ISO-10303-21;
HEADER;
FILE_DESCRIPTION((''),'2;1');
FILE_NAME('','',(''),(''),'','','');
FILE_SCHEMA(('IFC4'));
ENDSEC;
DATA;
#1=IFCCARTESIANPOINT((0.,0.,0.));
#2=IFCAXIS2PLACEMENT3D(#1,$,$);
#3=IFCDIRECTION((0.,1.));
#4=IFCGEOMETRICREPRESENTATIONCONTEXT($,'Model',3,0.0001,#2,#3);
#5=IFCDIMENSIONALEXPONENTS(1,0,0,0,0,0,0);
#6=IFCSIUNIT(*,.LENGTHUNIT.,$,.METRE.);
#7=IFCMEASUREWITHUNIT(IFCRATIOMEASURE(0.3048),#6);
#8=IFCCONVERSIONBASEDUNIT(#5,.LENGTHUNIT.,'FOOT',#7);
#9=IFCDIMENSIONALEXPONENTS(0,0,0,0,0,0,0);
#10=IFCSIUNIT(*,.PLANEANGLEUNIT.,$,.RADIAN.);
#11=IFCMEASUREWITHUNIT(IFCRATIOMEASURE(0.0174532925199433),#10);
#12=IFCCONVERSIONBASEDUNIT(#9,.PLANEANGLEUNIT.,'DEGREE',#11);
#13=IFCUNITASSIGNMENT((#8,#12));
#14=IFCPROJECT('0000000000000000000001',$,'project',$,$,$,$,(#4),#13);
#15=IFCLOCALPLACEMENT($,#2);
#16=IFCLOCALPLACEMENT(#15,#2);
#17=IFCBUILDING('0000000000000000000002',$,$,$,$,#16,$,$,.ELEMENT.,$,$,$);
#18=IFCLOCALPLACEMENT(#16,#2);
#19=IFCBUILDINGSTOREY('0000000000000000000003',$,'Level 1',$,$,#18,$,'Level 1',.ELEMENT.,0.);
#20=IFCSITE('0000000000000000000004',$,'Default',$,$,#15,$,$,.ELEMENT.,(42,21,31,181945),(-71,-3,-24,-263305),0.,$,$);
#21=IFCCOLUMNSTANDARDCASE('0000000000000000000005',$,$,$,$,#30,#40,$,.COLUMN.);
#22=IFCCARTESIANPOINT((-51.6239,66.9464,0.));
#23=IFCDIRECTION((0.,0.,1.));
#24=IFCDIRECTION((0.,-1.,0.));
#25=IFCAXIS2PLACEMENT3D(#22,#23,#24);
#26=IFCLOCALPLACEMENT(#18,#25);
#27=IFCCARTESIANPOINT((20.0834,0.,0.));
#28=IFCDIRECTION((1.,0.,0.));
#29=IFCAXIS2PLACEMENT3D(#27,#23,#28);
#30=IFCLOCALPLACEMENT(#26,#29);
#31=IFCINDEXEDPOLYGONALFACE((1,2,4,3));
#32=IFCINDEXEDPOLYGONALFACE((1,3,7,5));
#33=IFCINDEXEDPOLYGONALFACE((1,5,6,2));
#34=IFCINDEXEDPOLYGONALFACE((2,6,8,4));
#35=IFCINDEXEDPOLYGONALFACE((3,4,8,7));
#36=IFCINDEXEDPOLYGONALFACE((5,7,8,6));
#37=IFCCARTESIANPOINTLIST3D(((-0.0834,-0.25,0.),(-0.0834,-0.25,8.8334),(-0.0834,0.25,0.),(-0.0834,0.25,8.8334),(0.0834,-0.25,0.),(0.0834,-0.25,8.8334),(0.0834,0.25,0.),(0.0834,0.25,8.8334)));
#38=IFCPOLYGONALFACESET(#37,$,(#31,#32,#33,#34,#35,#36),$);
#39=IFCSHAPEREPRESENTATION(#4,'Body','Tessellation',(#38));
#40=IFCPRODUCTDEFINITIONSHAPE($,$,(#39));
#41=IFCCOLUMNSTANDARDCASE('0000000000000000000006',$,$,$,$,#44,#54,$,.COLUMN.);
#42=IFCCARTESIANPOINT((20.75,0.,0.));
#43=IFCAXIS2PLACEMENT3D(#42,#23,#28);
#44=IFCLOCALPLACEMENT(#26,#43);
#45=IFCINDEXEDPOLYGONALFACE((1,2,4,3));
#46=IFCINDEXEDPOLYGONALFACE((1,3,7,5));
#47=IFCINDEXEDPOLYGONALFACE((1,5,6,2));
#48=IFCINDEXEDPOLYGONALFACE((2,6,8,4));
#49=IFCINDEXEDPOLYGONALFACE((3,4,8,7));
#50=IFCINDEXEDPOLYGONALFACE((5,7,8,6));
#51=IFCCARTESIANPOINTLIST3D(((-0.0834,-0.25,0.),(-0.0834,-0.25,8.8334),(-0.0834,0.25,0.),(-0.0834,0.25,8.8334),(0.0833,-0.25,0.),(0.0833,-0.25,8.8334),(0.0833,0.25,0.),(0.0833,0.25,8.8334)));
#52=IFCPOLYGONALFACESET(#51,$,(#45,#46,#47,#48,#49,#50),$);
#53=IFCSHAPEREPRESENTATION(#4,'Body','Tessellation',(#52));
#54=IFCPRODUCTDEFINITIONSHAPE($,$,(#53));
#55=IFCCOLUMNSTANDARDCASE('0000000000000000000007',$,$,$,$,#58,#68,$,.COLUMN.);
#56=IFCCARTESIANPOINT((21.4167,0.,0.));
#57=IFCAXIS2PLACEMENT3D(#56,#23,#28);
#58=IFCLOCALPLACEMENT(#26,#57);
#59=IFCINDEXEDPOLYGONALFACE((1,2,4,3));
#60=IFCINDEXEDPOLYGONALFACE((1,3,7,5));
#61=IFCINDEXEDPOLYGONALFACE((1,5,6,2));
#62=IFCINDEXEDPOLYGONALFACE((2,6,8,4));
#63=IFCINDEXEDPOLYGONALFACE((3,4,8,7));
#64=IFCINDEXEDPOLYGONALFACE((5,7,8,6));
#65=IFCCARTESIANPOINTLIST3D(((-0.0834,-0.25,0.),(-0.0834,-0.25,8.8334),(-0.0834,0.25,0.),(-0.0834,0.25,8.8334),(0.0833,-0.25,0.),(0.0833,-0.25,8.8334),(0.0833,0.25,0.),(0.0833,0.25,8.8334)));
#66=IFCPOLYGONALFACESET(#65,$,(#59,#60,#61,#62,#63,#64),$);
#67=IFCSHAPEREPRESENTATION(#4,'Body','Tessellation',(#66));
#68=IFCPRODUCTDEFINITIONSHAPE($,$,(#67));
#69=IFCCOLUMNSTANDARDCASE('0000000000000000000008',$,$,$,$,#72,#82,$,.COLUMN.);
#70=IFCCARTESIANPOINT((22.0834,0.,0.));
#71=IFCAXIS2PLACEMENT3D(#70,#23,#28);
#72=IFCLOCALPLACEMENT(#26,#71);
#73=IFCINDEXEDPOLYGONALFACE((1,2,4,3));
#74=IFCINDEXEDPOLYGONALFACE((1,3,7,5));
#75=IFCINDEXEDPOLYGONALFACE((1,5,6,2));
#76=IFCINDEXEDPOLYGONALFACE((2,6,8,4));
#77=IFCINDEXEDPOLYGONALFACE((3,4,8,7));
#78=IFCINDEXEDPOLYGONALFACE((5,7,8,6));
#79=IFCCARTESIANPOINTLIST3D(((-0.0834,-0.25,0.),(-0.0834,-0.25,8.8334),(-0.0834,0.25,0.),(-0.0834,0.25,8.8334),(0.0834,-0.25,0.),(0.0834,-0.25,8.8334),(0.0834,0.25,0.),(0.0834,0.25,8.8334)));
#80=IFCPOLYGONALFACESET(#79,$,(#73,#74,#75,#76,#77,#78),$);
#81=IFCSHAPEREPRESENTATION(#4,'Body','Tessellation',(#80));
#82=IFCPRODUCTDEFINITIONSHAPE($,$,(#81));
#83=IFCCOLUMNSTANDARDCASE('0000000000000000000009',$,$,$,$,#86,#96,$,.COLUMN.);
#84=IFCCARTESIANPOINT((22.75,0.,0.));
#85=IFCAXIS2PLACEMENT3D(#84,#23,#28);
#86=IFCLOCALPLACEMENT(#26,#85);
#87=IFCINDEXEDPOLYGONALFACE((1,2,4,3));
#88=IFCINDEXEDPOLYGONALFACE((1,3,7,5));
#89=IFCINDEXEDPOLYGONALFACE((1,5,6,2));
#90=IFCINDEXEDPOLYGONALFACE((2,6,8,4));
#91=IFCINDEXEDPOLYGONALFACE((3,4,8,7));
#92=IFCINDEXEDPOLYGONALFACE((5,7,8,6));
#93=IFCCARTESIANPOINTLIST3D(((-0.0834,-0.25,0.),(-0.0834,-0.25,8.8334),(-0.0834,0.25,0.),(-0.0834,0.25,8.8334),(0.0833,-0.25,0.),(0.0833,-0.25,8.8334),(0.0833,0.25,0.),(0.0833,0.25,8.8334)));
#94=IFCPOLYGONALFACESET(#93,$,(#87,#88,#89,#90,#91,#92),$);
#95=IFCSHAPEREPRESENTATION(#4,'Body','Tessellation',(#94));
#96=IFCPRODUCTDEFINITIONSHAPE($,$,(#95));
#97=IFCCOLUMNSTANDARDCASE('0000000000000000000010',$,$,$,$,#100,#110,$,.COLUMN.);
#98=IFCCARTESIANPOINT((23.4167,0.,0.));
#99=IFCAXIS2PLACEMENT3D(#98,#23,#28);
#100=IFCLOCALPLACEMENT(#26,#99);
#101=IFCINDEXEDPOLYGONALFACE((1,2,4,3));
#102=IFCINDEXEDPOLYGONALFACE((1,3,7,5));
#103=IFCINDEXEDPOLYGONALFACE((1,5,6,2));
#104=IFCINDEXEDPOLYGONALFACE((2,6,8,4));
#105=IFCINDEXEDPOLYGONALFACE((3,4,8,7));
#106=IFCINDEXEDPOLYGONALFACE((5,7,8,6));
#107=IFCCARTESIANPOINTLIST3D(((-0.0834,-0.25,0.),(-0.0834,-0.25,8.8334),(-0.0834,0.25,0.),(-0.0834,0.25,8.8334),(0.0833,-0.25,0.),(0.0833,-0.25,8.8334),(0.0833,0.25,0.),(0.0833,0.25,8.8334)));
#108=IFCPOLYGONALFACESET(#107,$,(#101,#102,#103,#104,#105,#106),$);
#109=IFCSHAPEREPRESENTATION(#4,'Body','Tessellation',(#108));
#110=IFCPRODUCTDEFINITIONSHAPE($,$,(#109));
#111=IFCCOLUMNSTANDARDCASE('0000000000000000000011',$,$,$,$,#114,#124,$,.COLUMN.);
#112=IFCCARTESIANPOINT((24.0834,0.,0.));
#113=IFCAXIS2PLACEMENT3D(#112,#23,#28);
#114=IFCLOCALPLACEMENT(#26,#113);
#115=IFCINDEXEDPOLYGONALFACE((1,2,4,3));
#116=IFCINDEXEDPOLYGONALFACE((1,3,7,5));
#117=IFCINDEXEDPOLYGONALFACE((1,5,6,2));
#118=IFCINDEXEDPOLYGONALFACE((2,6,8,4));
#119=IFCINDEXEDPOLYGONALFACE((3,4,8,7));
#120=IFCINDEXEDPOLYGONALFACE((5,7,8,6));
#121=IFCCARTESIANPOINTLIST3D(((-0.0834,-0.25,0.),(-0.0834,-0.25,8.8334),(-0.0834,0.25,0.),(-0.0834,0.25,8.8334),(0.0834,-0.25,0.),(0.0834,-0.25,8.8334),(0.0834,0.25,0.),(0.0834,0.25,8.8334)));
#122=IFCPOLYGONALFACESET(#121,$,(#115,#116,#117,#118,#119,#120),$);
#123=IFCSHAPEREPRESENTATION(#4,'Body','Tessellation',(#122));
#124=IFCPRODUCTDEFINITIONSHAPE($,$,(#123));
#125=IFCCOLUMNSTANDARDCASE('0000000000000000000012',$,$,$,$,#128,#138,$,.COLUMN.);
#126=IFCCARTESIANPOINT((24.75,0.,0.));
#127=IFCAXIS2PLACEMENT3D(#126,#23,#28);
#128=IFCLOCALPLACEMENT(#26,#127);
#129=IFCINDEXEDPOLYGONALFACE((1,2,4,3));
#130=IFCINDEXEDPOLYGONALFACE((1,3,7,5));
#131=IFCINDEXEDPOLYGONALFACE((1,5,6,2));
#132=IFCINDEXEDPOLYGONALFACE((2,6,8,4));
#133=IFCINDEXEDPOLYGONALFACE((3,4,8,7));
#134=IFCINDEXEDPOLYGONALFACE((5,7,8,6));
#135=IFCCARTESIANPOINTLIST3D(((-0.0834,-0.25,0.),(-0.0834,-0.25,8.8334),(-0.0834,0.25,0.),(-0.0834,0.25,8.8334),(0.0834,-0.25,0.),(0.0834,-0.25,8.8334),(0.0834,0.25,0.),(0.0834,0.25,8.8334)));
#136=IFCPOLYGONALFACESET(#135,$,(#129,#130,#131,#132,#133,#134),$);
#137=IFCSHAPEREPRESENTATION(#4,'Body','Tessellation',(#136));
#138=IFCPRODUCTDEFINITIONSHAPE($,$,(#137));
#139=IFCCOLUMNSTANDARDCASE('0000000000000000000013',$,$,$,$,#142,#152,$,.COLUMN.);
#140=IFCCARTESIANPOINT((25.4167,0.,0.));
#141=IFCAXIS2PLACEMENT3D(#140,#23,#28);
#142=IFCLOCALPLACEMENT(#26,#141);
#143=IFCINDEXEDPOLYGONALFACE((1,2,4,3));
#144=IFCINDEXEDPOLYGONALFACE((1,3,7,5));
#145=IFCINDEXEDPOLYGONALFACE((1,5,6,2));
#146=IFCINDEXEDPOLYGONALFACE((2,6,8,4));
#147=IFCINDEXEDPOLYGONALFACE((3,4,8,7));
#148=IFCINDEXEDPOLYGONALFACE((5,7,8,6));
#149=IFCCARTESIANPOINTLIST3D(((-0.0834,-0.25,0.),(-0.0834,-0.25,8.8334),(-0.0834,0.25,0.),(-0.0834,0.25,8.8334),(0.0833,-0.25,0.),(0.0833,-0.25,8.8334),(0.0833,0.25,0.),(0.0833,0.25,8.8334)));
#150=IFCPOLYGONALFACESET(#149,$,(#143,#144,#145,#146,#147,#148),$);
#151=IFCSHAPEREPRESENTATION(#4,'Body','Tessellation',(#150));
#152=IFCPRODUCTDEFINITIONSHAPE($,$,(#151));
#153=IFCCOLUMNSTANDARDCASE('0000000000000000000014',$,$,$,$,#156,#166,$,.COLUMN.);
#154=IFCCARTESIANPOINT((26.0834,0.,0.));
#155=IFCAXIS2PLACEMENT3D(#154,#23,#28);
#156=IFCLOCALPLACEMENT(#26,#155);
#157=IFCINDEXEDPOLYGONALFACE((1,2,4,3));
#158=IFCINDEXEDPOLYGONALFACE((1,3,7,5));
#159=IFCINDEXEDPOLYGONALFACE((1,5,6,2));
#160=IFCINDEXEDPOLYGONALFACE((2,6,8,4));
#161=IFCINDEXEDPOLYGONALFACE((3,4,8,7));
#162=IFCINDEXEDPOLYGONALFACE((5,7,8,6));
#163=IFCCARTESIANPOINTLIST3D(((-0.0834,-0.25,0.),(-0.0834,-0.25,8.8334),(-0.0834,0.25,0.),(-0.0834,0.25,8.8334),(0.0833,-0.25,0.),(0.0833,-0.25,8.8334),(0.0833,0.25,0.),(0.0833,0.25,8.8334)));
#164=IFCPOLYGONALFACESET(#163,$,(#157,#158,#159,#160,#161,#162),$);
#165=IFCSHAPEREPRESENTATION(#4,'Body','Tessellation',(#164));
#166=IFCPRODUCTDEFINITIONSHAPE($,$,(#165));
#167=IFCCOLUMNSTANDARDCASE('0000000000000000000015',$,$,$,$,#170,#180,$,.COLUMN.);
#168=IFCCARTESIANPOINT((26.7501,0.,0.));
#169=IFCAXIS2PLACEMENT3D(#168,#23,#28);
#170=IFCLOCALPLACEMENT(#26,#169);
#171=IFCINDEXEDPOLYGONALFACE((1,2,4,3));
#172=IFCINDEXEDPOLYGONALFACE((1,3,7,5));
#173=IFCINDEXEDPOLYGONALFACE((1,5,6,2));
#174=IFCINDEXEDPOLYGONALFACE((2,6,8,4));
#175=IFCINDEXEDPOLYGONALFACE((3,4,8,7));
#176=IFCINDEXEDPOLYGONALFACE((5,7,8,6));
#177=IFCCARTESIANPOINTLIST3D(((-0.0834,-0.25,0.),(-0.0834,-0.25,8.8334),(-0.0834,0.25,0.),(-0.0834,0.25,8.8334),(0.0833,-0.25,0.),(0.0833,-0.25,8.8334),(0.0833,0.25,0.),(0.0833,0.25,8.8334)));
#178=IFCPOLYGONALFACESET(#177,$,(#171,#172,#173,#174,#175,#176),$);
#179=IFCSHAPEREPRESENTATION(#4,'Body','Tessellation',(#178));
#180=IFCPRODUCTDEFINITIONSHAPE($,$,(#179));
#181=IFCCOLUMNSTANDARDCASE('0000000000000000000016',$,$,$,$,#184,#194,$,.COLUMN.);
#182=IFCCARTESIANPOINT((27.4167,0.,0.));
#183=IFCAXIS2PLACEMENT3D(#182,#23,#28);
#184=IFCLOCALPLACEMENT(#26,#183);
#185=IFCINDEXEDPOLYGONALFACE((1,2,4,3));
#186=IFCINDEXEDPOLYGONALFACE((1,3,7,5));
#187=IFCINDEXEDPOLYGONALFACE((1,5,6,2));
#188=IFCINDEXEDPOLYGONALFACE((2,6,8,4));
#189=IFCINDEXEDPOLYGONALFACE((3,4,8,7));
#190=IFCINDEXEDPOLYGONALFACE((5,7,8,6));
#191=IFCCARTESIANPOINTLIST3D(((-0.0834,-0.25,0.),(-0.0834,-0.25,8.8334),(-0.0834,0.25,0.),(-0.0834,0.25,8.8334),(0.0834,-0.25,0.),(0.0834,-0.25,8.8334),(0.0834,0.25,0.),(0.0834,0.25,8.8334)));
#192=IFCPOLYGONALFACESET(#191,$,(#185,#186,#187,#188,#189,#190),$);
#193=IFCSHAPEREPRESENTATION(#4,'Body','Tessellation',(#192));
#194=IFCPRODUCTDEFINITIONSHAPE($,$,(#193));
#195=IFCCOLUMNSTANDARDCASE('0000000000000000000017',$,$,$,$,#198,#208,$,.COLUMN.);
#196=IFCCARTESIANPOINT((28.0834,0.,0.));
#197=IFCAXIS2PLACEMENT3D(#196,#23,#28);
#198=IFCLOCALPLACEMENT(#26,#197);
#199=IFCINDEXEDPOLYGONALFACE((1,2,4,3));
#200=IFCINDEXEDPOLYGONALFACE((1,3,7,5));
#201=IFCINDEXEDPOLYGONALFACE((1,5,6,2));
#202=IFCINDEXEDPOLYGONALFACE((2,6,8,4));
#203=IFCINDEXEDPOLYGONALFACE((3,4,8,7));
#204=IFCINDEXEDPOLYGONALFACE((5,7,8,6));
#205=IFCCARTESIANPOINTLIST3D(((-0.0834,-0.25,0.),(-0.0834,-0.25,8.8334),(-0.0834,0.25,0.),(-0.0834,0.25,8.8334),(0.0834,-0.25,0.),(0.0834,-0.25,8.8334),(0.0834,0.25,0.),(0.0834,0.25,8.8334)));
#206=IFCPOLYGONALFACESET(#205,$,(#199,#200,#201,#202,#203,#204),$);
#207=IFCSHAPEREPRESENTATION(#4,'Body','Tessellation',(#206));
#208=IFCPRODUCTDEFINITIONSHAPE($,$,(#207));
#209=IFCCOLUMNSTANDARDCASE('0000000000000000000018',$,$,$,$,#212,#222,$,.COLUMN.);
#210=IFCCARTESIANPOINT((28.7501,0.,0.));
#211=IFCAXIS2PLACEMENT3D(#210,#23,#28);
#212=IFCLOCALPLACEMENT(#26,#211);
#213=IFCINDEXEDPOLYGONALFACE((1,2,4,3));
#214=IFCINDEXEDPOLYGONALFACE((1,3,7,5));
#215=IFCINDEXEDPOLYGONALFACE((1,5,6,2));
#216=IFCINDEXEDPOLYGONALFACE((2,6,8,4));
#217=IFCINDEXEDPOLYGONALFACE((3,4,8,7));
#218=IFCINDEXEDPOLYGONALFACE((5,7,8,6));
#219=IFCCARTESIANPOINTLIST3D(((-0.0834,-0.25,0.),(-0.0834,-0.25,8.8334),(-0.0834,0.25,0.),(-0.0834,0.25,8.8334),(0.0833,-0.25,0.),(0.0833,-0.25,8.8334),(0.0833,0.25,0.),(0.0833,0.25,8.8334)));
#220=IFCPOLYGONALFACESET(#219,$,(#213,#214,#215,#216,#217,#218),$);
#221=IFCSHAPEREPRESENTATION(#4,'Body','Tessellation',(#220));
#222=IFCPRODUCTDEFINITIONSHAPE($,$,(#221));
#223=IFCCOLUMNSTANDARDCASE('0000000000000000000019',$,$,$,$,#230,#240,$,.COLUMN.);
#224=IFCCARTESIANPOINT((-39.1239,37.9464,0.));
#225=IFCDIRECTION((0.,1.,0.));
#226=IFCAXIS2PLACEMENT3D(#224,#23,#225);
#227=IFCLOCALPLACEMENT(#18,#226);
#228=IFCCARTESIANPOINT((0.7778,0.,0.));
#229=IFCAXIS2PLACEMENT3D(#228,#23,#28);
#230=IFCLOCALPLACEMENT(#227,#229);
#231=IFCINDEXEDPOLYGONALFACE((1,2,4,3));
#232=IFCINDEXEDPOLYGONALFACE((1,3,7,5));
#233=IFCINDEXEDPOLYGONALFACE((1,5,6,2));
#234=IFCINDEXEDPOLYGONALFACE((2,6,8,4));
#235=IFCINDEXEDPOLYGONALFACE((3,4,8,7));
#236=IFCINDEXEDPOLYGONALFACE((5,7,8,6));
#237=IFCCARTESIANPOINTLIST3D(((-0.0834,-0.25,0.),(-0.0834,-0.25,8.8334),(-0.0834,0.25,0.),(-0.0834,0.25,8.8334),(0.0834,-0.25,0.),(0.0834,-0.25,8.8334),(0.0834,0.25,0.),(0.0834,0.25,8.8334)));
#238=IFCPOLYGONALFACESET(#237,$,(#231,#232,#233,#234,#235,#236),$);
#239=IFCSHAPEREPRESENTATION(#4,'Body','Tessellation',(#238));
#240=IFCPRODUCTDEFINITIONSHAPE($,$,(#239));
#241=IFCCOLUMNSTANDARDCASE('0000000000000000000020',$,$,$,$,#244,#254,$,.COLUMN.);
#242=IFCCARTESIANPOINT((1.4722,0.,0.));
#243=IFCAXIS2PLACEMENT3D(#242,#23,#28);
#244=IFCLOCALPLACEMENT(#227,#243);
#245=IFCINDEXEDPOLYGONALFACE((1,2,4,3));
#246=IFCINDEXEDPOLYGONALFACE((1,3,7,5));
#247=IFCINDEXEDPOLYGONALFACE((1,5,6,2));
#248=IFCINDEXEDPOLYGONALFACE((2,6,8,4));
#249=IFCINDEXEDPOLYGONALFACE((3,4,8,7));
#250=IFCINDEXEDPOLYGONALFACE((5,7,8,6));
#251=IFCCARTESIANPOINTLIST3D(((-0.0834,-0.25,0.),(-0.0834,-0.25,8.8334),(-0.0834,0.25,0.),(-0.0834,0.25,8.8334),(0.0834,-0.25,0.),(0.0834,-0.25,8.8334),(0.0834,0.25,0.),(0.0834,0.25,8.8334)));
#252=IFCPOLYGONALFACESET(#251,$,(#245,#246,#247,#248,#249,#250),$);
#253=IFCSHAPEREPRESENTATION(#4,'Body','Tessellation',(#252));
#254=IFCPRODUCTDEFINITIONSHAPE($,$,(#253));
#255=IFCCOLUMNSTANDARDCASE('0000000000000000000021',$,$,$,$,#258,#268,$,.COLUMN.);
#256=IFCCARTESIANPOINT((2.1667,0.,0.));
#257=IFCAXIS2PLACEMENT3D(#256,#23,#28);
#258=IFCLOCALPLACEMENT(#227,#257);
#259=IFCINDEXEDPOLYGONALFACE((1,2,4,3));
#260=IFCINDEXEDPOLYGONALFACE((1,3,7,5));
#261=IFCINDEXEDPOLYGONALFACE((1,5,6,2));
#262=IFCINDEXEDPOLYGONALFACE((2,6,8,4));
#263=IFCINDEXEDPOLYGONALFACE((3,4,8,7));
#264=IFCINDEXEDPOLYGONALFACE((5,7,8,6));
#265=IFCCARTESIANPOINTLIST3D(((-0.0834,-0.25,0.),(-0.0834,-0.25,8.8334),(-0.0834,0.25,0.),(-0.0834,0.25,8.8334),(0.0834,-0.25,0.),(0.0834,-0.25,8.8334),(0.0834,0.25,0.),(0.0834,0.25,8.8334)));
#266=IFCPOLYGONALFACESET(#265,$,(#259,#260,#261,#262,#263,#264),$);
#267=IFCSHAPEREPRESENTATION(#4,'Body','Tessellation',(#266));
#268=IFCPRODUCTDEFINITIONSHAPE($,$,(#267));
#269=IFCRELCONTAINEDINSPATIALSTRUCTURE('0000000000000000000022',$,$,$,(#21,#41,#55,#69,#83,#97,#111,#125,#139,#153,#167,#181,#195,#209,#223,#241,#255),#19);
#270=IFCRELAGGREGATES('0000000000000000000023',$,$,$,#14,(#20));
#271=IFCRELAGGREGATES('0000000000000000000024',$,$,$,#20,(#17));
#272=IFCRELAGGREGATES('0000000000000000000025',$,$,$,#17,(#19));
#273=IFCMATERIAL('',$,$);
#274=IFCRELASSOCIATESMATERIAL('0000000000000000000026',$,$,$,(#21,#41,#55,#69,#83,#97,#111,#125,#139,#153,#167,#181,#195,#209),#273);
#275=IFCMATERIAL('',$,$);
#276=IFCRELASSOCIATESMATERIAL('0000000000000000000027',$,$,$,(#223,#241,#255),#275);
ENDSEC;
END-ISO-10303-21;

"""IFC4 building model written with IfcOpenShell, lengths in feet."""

from ifc_helpers import new_model, entity, si_unit, converted_unit, direction, frame, origin, place, context, project, spatial, rectangle, extrude, material, element, save


model = new_model("IFC4")

# Units and contexts
model_context = context("Model", 3, precision=0.0001, world=origin(), true_north=direction((0.0, 1.0)))
ifc_project = project(units=[converted_unit("LENGTHUNIT", "FOOT", entity("IfcRatioMeasure", 0.3048), si_unit("LENGTHUNIT", "METRE"), dimensions=[1, 0, 0, 0, 0, 0, 0]), converted_unit("PLANEANGLEUNIT", "DEGREE", entity("IfcRatioMeasure", 0.0174532925199433), si_unit("PLANEANGLEUNIT", "RADIAN"), dimensions=[0, 0, 0, 0, 0, 0, 0])], contexts=[model_context])

# Site, building, storey
site_placement = place(None, origin())
site = spatial("IfcSite", under=ifc_project, at=site_placement, Name="Default", CompositionType="ELEMENT", RefLatitude=(42, 21, 31, 181945), RefLongitude=(-71, -3, -24, -263305), RefElevation=0.0)
building_placement = place(site_placement, origin())
building = spatial("IfcBuilding", under=site, at=building_placement, CompositionType="ELEMENT")
storey_placement = place(building_placement, origin())
storey = spatial("IfcBuildingStorey", under=building, at=storey_placement, Name="Level 1", LongName="Level 1", CompositionType="ELEMENT", Elevation=0.0)

# Columns
ifc_material_1 = material(Name="")
placement_1 = place(storey_placement, frame((-51.6239, 66.9464, 0.0), z_axis=(0.0, 0.0, 1.0), x_axis=(0.0, -1.0, 0.0)))
for number, where, z_axis, x_axis in (
    (1, (20.0834, 0.0, 0.0), (0.0, 0.0, 1.0), (1.0, 0.0, 0.0)),
    (2, (20.75, 0.0, 0.0), (0.0, 0.0, 1.0), (1.0, 0.0, 0.0)),
    (3, (21.4167, 0.0, 0.0), (0.0, 0.0, 1.0), (1.0, 0.0, 0.0)),
    (4, (22.0834, 0.0, 0.0), (0.0, 0.0, 1.0), (1.0, 0.0, 0.0)),
    (5, (22.75, 0.0, 0.0), (0.0, 0.0, 1.0), (1.0, 0.0, 0.0)),
    (6, (23.4167, 0.0, 0.0), (0.0, 0.0, 1.0), (1.0, 0.0, 0.0)),
    (7, (24.0834, 0.0, 0.0), (0.0, 0.0, 1.0), (1.0, 0.0, 0.0)),
    (8, (24.75, 0.0, 0.0), (0.0, 0.0, 1.0), (1.0, 0.0, 0.0)),
    (9, (25.4167, 0.0, 0.0), (0.0, 0.0, 1.0), (1.0, 0.0, 0.0)),
    (10, (26.0834, 0.0, 0.0), (0.0, 0.0, 1.0), (1.0, 0.0, 0.0)),
    (11, (26.7501, 0.0, 0.0), (0.0, 0.0, 1.0), (1.0, 0.0, 0.0)),
    (12, (27.4167, 0.0, 0.0), (0.0, 0.0, 1.0), (1.0, 0.0, 0.0)),
    (13, (28.0834, 0.0, 0.0), (0.0, 0.0, 1.0), (1.0, 0.0, 0.0)),
    (14, (28.7501, 0.0, 0.0), (0.0, 0.0, 1.0), (1.0, 0.0, 0.0)),
):
    element("IfcColumnStandardCase", number, at=place(placement_1, frame(where, z_axis=z_axis, x_axis=x_axis)), inside=storey, material=ifc_material_1, PredefinedType="COLUMN", context=model_context, shape_type="SweptSolid", body=[
        extrude(rectangle(XDim=0.1667, YDim=0.5), origin(), (0.0, 0.0, 1.0), 8.8334),
    ])
ifc_material_2 = material(Name="")
placement_2 = place(storey_placement, frame((-39.1239, 37.9464, 0.0), z_axis=(0.0, 0.0, 1.0), x_axis=(0.0, 1.0, 0.0)))
for number, where, z_axis, x_axis in (
    (15, (0.7778, 0.0, 0.0), (0.0, 0.0, 1.0), (1.0, 0.0, 0.0)),
    (16, (1.4722, 0.0, 0.0), (0.0, 0.0, 1.0), (1.0, 0.0, 0.0)),
    (17, (2.1667, 0.0, 0.0), (0.0, 0.0, 1.0), (1.0, 0.0, 0.0)),
):
    element("IfcColumnStandardCase", number, at=place(placement_2, frame(where, z_axis=z_axis, x_axis=x_axis)), inside=storey, material=ifc_material_2, PredefinedType="COLUMN", context=model_context, shape_type="SweptSolid", body=[
        extrude(rectangle(XDim=0.1667, YDim=0.5), origin(), (0.0, 0.0, 1.0), 8.8334),
    ])

save(model, "model.ifc")
